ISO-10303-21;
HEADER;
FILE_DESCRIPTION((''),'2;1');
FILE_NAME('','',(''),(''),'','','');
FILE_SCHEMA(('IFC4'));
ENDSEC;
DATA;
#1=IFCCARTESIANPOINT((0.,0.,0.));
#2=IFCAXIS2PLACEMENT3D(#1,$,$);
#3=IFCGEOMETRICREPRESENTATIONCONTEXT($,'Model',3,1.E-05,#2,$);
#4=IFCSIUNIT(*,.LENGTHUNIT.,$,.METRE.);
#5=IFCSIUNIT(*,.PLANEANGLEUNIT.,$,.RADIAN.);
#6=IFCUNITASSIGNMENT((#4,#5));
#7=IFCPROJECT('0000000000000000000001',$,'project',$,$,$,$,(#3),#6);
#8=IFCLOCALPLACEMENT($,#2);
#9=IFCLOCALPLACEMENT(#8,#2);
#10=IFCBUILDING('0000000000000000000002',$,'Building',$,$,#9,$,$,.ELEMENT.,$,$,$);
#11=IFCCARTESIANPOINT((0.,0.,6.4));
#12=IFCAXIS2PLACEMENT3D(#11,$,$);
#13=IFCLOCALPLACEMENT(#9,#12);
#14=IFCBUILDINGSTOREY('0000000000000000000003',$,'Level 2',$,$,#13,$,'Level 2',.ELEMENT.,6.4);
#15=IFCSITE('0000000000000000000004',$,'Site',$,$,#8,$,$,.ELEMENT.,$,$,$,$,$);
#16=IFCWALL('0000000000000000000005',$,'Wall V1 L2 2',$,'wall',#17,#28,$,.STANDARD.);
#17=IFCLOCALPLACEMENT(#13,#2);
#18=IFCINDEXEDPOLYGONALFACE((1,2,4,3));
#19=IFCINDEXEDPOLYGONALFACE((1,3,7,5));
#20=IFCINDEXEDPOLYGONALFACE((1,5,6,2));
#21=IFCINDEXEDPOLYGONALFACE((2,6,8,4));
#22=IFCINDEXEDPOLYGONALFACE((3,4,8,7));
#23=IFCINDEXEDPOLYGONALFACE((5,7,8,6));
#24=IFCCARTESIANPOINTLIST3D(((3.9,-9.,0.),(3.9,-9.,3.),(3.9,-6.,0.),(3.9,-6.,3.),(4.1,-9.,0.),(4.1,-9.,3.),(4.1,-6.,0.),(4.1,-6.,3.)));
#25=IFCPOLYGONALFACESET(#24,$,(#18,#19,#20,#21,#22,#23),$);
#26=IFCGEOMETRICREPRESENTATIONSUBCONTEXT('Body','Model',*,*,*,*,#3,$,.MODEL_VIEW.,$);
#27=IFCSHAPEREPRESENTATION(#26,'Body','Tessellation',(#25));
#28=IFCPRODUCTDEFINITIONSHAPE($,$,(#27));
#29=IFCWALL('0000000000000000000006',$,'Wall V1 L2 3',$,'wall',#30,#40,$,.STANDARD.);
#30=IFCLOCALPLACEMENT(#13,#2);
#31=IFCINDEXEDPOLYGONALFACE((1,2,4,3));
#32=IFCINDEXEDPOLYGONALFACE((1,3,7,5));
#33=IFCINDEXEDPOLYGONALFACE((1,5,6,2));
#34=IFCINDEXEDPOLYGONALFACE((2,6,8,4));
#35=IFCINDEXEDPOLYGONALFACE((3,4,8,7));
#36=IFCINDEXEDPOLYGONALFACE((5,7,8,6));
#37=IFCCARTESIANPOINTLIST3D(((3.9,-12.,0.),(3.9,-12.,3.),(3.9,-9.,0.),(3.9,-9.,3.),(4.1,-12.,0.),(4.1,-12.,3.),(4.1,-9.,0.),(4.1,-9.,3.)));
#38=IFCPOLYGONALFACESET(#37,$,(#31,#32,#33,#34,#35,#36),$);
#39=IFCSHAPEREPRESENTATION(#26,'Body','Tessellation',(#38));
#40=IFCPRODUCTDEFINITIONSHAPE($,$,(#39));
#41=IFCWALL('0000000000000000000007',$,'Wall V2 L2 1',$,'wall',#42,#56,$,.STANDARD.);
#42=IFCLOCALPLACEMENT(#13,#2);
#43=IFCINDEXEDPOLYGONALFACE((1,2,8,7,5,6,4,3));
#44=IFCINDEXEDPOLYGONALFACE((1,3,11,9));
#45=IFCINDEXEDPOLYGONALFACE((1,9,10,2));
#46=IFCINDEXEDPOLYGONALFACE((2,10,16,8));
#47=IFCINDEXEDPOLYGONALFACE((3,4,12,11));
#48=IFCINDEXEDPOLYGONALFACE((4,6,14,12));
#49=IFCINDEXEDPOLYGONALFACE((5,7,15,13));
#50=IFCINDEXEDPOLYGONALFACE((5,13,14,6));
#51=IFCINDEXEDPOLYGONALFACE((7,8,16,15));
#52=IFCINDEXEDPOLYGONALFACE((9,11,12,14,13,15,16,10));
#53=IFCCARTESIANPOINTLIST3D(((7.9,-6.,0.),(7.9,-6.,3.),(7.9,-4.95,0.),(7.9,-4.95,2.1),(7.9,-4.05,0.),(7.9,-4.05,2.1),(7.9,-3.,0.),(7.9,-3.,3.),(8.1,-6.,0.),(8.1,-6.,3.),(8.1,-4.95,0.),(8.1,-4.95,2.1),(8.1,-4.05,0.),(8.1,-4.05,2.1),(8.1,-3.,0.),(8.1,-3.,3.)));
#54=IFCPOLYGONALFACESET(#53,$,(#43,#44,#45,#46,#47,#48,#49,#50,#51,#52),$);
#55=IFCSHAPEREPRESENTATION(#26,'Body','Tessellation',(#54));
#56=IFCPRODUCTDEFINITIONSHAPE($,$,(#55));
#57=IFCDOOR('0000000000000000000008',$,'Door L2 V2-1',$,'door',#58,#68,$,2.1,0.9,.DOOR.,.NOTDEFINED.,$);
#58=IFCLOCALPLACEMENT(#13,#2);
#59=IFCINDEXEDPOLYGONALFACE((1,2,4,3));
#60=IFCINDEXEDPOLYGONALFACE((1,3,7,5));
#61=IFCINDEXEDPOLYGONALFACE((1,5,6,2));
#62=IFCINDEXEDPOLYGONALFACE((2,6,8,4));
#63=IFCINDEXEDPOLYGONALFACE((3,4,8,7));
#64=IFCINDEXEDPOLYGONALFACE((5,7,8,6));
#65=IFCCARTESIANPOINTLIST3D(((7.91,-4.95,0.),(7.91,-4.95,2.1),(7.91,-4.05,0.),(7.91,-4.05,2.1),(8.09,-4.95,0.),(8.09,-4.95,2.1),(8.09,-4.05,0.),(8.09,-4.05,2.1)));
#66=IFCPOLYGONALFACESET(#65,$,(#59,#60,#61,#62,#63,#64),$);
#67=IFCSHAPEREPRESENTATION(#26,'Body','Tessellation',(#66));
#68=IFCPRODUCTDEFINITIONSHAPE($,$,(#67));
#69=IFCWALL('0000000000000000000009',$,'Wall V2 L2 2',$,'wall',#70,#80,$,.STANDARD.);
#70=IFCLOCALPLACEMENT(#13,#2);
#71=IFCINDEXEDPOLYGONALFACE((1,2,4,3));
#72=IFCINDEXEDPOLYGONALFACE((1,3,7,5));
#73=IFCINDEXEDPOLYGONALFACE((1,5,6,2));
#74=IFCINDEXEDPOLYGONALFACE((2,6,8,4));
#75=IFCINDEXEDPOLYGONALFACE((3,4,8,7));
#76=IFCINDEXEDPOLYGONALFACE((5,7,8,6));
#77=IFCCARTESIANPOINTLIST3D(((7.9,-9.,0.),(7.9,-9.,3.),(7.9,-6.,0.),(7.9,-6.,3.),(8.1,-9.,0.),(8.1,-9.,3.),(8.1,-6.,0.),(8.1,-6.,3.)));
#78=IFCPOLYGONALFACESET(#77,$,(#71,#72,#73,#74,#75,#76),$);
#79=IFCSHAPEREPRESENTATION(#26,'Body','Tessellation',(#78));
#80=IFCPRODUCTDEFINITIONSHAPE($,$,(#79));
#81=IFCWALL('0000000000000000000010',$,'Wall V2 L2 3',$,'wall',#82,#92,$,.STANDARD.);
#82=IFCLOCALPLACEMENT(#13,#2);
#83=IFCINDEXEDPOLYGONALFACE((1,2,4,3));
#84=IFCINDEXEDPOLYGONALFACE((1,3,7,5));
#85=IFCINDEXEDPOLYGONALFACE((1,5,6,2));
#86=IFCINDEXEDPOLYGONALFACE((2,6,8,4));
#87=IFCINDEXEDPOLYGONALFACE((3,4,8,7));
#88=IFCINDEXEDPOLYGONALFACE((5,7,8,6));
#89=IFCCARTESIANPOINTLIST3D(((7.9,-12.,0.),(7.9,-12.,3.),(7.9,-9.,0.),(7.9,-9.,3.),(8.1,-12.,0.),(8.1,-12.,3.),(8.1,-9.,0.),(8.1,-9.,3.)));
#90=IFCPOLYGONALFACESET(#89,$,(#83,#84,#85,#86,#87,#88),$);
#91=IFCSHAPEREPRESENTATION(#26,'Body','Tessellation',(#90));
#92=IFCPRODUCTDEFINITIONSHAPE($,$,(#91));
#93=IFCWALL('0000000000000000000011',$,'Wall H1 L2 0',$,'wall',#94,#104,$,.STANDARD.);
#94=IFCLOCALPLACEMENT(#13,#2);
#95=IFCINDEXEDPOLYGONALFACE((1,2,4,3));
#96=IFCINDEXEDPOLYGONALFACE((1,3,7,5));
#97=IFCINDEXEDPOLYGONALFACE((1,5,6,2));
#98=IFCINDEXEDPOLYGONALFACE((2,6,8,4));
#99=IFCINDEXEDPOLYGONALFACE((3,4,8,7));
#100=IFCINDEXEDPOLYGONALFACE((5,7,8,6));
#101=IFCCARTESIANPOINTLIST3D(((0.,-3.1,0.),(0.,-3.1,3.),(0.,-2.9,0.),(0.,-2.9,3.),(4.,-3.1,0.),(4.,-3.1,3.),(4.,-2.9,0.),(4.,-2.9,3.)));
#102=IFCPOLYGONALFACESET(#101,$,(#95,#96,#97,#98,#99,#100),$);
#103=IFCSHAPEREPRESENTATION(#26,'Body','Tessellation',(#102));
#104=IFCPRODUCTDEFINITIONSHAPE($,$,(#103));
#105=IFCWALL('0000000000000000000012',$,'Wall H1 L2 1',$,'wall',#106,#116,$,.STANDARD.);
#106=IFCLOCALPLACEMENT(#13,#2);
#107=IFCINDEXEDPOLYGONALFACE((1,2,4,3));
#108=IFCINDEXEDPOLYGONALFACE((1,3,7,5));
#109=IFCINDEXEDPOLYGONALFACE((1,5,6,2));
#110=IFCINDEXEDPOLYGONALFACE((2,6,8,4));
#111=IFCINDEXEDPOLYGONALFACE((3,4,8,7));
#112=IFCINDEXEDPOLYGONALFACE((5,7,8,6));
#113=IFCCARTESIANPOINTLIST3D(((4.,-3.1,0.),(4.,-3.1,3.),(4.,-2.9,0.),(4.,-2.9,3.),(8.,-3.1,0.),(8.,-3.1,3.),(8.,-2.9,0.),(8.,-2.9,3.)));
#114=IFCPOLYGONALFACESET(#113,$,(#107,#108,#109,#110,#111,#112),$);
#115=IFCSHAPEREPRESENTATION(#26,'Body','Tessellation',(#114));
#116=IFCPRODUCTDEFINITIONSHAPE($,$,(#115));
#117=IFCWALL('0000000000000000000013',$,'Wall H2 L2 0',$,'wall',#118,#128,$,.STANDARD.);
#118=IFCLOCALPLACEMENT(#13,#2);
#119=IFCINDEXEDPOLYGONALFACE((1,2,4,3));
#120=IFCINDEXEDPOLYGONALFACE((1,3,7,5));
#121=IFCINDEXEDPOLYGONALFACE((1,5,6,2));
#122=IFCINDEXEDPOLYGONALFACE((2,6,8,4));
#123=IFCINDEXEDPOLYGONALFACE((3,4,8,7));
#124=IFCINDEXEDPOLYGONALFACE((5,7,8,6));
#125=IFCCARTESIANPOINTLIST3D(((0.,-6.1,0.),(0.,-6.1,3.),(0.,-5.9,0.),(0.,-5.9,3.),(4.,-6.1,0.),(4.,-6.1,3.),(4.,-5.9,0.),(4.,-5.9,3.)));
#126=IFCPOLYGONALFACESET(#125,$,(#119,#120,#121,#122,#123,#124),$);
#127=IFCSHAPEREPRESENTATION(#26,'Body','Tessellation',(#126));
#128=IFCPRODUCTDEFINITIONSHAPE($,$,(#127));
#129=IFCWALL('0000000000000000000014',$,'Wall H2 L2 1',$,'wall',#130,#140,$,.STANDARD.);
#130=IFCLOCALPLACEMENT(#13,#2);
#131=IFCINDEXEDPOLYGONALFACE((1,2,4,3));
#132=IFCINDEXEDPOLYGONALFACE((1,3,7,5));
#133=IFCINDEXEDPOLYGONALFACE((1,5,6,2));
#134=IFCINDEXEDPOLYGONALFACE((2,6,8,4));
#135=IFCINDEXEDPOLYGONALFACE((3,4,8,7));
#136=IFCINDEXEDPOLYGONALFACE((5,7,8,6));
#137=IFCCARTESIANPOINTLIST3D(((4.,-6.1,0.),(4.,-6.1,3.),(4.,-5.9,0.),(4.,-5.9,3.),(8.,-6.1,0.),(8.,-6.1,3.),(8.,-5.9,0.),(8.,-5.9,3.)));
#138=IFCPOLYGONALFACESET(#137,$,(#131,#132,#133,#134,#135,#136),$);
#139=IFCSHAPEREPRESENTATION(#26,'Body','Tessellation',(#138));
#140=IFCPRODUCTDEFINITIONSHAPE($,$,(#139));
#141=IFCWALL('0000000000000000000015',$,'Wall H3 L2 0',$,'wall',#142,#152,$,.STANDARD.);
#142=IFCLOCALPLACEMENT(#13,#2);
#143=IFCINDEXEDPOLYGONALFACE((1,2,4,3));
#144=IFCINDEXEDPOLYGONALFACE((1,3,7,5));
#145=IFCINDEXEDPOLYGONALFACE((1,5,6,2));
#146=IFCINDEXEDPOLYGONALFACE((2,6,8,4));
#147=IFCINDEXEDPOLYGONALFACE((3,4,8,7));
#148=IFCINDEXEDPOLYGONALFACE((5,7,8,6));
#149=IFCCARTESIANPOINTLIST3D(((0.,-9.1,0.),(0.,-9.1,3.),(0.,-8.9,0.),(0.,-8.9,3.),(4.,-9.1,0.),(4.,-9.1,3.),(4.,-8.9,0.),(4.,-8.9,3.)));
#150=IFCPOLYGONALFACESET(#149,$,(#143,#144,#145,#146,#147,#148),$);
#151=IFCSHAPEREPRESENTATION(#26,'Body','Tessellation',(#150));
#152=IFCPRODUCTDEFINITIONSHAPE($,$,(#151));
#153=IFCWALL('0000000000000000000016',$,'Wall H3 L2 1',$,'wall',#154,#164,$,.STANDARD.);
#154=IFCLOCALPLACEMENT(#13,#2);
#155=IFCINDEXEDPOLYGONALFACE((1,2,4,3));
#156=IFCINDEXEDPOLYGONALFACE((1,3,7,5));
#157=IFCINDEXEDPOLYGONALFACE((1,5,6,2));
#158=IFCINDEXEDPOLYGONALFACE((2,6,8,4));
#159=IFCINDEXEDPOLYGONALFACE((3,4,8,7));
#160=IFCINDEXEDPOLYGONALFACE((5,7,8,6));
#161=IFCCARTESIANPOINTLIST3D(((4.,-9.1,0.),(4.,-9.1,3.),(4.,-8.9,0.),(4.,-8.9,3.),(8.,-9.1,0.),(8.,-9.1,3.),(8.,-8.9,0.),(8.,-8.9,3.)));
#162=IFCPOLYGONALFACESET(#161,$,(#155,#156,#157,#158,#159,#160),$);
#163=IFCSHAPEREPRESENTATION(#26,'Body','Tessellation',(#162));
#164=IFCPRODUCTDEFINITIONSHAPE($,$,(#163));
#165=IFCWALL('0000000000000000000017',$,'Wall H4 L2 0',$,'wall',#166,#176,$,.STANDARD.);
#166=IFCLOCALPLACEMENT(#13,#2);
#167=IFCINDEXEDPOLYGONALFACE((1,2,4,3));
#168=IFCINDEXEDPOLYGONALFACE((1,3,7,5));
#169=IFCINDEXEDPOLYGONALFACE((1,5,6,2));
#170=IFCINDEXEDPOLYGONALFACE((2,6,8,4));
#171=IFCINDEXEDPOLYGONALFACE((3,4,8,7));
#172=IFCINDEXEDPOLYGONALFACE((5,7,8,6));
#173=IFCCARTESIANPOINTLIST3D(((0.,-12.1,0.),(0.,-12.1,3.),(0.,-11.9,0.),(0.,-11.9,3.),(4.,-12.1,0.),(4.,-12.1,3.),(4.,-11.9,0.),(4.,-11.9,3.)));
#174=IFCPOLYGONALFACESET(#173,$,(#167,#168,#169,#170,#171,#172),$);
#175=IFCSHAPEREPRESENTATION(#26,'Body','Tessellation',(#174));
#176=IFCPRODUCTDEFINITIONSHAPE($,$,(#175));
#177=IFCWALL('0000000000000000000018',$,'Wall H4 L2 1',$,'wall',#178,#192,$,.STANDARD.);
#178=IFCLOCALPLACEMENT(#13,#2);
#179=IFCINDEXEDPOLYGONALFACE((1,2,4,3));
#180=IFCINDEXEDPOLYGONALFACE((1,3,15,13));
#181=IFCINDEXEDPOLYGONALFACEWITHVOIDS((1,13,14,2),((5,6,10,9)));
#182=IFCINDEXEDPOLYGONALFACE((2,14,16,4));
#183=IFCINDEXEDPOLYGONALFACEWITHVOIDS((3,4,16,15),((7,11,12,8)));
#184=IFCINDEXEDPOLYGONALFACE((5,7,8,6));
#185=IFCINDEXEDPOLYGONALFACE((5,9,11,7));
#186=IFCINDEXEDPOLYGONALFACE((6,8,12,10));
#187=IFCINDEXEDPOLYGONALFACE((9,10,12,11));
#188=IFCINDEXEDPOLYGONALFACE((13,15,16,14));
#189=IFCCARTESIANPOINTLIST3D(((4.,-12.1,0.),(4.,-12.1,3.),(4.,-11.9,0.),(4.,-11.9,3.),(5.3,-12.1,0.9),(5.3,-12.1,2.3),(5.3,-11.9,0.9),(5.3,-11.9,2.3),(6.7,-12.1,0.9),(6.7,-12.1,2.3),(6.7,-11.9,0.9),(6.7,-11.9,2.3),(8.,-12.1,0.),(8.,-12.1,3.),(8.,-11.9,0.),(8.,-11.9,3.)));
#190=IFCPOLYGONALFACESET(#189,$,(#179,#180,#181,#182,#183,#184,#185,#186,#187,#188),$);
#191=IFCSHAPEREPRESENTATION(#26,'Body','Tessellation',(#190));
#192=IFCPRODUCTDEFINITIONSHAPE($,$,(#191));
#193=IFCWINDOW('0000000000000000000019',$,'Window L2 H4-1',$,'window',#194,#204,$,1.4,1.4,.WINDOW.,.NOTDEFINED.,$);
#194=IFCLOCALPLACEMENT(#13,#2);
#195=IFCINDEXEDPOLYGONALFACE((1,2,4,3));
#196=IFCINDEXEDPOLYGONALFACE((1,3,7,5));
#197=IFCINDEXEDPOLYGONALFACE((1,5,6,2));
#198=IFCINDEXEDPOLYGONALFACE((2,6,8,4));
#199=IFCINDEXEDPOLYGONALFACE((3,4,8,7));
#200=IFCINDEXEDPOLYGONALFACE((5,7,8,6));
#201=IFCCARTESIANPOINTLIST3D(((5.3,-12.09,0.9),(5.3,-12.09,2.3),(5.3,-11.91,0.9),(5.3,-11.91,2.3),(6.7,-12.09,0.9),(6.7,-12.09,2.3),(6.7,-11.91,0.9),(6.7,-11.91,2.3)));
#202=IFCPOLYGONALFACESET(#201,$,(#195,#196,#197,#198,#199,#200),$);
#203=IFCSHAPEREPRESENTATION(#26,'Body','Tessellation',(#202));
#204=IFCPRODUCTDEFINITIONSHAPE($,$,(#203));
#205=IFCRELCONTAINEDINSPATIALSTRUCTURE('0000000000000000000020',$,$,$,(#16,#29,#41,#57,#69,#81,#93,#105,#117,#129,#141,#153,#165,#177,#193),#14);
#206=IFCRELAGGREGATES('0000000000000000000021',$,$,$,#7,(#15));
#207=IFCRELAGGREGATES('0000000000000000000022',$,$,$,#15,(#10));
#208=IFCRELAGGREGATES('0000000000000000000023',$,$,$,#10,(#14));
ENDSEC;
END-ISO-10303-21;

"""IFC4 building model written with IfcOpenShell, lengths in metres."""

from ifc_helpers import new_model, si_unit, frame, frame_2d, origin, origin_2d, place, context, subcontext, project, spatial, rectangle, extrude, element, fill, save


model = new_model("IFC4")

# Units and contexts
model_context = context("Model", 3, precision=1e-05, world=origin())
body_context = subcontext(model_context, "Body", "Model", "MODEL_VIEW")
ifc_project = project(units=[si_unit("LENGTHUNIT", "METRE"), si_unit("PLANEANGLEUNIT", "RADIAN")], contexts=[model_context])

# Site, building, storey
site_placement = place(None, origin())
site = spatial("IfcSite", under=ifc_project, at=site_placement, Name="Site", CompositionType="ELEMENT")
building_placement = place(site_placement, origin())
building = spatial("IfcBuilding", under=site, at=building_placement, Name="Building", CompositionType="ELEMENT")
storey_placement = place(building_placement, frame((0.0, 0.0, 6.4)))
storey = spatial("IfcBuildingStorey", under=building, at=storey_placement, Name="Level 2", LongName="Level 2", CompositionType="ELEMENT", Elevation=6.4)

# Walls
for number, where, z_axis, x_axis, name in (
    (1, (4.0, -6.0, 0.0), (0.0, 0.0, 1.0), (0.0, -1.0, 0.0), "Wall V1 L2 2"),
    (2, (4.0, -9.0, 0.0), (0.0, 0.0, 1.0), (0.0, -1.0, 0.0), "Wall V1 L2 3"),
):
    element("IfcWall", number, at=place(storey_placement, frame(where, z_axis=z_axis, x_axis=x_axis)), inside=storey, Name=name, ObjectType="wall", PredefinedType="STANDARD", context=body_context, shape_type="SweptSolid", body=[
        extrude(rectangle(XDim=3.0, YDim=0.2, at=frame_2d((1.5, 0.0))), origin(), (0.0, 0.0, 1.0), 3.0),
    ])

# Wall, opening, door
wall_1_placement = place(storey_placement, frame((8.0, -3.0, 0.0), z_axis=(0.0, 0.0, 1.0), x_axis=(0.0, -1.0, 0.0)))
wall_1 = element("IfcWall", 3, at=wall_1_placement, inside=storey, Name="Wall V2 L2 1", ObjectType="wall", PredefinedType="STANDARD", context=body_context, shape_type="SweptSolid", body=[
    extrude(rectangle(XDim=3.0, YDim=0.2, at=frame_2d((1.5, 0.0))), origin(), (0.0, 0.0, 1.0), 3.0),
])
opening_1_placement = place(storey_placement, frame((8.0, -4.5, 0.0), z_axis=(0.0, 0.0, 1.0), x_axis=(0.0, -1.0, 0.0)))
opening_1 = element("IfcOpeningElement", 4, at=opening_1_placement, cuts=wall_1, ObjectType="Opening", PredefinedType="OPENING", context=body_context, shape_type="SweptSolid", body=[
    extrude(rectangle(XDim=0.9, YDim=0.22, at=origin_2d()), origin(), (0.0, 0.0, 1.0), 2.1),
])
door_1_placement = place(storey_placement, frame((8.0, -4.5, 0.0), z_axis=(0.0, 0.0, 1.0), x_axis=(0.0, -1.0, 0.0)))
door_1 = element("IfcDoor", 5, at=door_1_placement, inside=storey, Name="Door L2 V2-1", ObjectType="door", OperationType="NOTDEFINED", OverallHeight=2.1, OverallWidth=0.9, PredefinedType="DOOR", context=body_context, shape_type="SweptSolid", body=[
    extrude(rectangle(XDim=0.9, YDim=0.18, at=origin_2d()), origin(), (0.0, 0.0, 1.0), 2.1),
])
fill(opening_1, door_1)

# Walls
for number, where, z_axis, x_axis, name in (
    (6, (8.0, -6.0, 0.0), (0.0, 0.0, 1.0), (0.0, -1.0, 0.0), "Wall V2 L2 2"),
    (7, (8.0, -9.0, 0.0), (0.0, 0.0, 1.0), (0.0, -1.0, 0.0), "Wall V2 L2 3"),
):
    element("IfcWall", number, at=place(storey_placement, frame(where, z_axis=z_axis, x_axis=x_axis)), inside=storey, Name=name, ObjectType="wall", PredefinedType="STANDARD", context=body_context, shape_type="SweptSolid", body=[
        extrude(rectangle(XDim=3.0, YDim=0.2, at=frame_2d((1.5, 0.0))), origin(), (0.0, 0.0, 1.0), 3.0),
    ])
for number, where, z_axis, x_axis, name in (
    (8, (0.0, -3.0, 0.0), (0.0, 0.0, 1.0), (1.0, 0.0, 0.0), "Wall H1 L2 0"),
    (9, (4.0, -3.0, 0.0), (0.0, 0.0, 1.0), (1.0, 0.0, 0.0), "Wall H1 L2 1"),
    (10, (0.0, -6.0, 0.0), (0.0, 0.0, 1.0), (1.0, 0.0, 0.0), "Wall H2 L2 0"),
    (11, (4.0, -6.0, 0.0), (0.0, 0.0, 1.0), (1.0, 0.0, 0.0), "Wall H2 L2 1"),
    (12, (0.0, -9.0, 0.0), (0.0, 0.0, 1.0), (1.0, 0.0, 0.0), "Wall H3 L2 0"),
    (13, (4.0, -9.0, 0.0), (0.0, 0.0, 1.0), (1.0, 0.0, 0.0), "Wall H3 L2 1"),
    (14, (0.0, -12.0, 0.0), (0.0, 0.0, 1.0), (1.0, 0.0, 0.0), "Wall H4 L2 0"),
):
    element("IfcWall", number, at=place(storey_placement, frame(where, z_axis=z_axis, x_axis=x_axis)), inside=storey, Name=name, ObjectType="wall", PredefinedType="STANDARD", context=body_context, shape_type="SweptSolid", body=[
        extrude(rectangle(XDim=4.0, YDim=0.2, at=frame_2d((2.0, 0.0))), origin(), (0.0, 0.0, 1.0), 3.0),
    ])

# Wall, opening, window
wall_2_placement = place(storey_placement, frame((4.0, -12.0, 0.0), z_axis=(0.0, 0.0, 1.0), x_axis=(1.0, 0.0, 0.0)))
wall_2 = element("IfcWall", 15, at=wall_2_placement, inside=storey, Name="Wall H4 L2 1", ObjectType="wall", PredefinedType="STANDARD", context=body_context, shape_type="SweptSolid", body=[
    extrude(rectangle(XDim=4.0, YDim=0.2, at=frame_2d((2.0, 0.0))), origin(), (0.0, 0.0, 1.0), 3.0),
])
opening_2_placement = place(storey_placement, frame((6.0, -12.0, 0.9), z_axis=(0.0, 0.0, 1.0), x_axis=(1.0, 0.0, 0.0)))
opening_2 = element("IfcOpeningElement", 16, at=opening_2_placement, cuts=wall_2, ObjectType="Opening", PredefinedType="OPENING", context=body_context, shape_type="SweptSolid", body=[
    extrude(rectangle(XDim=1.4, YDim=0.22, at=origin_2d()), origin(), (0.0, 0.0, 1.0), 1.4),
])
window_1_placement = place(storey_placement, frame((6.0, -12.0, 0.9), z_axis=(0.0, 0.0, 1.0), x_axis=(1.0, 0.0, 0.0)))
window_1 = element("IfcWindow", 17, at=window_1_placement, inside=storey, Name="Window L2 H4-1", ObjectType="window", OverallHeight=1.4, OverallWidth=1.4, PartitioningType="NOTDEFINED", PredefinedType="WINDOW", context=body_context, shape_type="SweptSolid", body=[
    extrude(rectangle(XDim=1.4, YDim=0.18, at=origin_2d()), origin(), (0.0, 0.0, 1.0), 1.4),
])
fill(opening_2, window_1)

save(model, "model.ifc")
